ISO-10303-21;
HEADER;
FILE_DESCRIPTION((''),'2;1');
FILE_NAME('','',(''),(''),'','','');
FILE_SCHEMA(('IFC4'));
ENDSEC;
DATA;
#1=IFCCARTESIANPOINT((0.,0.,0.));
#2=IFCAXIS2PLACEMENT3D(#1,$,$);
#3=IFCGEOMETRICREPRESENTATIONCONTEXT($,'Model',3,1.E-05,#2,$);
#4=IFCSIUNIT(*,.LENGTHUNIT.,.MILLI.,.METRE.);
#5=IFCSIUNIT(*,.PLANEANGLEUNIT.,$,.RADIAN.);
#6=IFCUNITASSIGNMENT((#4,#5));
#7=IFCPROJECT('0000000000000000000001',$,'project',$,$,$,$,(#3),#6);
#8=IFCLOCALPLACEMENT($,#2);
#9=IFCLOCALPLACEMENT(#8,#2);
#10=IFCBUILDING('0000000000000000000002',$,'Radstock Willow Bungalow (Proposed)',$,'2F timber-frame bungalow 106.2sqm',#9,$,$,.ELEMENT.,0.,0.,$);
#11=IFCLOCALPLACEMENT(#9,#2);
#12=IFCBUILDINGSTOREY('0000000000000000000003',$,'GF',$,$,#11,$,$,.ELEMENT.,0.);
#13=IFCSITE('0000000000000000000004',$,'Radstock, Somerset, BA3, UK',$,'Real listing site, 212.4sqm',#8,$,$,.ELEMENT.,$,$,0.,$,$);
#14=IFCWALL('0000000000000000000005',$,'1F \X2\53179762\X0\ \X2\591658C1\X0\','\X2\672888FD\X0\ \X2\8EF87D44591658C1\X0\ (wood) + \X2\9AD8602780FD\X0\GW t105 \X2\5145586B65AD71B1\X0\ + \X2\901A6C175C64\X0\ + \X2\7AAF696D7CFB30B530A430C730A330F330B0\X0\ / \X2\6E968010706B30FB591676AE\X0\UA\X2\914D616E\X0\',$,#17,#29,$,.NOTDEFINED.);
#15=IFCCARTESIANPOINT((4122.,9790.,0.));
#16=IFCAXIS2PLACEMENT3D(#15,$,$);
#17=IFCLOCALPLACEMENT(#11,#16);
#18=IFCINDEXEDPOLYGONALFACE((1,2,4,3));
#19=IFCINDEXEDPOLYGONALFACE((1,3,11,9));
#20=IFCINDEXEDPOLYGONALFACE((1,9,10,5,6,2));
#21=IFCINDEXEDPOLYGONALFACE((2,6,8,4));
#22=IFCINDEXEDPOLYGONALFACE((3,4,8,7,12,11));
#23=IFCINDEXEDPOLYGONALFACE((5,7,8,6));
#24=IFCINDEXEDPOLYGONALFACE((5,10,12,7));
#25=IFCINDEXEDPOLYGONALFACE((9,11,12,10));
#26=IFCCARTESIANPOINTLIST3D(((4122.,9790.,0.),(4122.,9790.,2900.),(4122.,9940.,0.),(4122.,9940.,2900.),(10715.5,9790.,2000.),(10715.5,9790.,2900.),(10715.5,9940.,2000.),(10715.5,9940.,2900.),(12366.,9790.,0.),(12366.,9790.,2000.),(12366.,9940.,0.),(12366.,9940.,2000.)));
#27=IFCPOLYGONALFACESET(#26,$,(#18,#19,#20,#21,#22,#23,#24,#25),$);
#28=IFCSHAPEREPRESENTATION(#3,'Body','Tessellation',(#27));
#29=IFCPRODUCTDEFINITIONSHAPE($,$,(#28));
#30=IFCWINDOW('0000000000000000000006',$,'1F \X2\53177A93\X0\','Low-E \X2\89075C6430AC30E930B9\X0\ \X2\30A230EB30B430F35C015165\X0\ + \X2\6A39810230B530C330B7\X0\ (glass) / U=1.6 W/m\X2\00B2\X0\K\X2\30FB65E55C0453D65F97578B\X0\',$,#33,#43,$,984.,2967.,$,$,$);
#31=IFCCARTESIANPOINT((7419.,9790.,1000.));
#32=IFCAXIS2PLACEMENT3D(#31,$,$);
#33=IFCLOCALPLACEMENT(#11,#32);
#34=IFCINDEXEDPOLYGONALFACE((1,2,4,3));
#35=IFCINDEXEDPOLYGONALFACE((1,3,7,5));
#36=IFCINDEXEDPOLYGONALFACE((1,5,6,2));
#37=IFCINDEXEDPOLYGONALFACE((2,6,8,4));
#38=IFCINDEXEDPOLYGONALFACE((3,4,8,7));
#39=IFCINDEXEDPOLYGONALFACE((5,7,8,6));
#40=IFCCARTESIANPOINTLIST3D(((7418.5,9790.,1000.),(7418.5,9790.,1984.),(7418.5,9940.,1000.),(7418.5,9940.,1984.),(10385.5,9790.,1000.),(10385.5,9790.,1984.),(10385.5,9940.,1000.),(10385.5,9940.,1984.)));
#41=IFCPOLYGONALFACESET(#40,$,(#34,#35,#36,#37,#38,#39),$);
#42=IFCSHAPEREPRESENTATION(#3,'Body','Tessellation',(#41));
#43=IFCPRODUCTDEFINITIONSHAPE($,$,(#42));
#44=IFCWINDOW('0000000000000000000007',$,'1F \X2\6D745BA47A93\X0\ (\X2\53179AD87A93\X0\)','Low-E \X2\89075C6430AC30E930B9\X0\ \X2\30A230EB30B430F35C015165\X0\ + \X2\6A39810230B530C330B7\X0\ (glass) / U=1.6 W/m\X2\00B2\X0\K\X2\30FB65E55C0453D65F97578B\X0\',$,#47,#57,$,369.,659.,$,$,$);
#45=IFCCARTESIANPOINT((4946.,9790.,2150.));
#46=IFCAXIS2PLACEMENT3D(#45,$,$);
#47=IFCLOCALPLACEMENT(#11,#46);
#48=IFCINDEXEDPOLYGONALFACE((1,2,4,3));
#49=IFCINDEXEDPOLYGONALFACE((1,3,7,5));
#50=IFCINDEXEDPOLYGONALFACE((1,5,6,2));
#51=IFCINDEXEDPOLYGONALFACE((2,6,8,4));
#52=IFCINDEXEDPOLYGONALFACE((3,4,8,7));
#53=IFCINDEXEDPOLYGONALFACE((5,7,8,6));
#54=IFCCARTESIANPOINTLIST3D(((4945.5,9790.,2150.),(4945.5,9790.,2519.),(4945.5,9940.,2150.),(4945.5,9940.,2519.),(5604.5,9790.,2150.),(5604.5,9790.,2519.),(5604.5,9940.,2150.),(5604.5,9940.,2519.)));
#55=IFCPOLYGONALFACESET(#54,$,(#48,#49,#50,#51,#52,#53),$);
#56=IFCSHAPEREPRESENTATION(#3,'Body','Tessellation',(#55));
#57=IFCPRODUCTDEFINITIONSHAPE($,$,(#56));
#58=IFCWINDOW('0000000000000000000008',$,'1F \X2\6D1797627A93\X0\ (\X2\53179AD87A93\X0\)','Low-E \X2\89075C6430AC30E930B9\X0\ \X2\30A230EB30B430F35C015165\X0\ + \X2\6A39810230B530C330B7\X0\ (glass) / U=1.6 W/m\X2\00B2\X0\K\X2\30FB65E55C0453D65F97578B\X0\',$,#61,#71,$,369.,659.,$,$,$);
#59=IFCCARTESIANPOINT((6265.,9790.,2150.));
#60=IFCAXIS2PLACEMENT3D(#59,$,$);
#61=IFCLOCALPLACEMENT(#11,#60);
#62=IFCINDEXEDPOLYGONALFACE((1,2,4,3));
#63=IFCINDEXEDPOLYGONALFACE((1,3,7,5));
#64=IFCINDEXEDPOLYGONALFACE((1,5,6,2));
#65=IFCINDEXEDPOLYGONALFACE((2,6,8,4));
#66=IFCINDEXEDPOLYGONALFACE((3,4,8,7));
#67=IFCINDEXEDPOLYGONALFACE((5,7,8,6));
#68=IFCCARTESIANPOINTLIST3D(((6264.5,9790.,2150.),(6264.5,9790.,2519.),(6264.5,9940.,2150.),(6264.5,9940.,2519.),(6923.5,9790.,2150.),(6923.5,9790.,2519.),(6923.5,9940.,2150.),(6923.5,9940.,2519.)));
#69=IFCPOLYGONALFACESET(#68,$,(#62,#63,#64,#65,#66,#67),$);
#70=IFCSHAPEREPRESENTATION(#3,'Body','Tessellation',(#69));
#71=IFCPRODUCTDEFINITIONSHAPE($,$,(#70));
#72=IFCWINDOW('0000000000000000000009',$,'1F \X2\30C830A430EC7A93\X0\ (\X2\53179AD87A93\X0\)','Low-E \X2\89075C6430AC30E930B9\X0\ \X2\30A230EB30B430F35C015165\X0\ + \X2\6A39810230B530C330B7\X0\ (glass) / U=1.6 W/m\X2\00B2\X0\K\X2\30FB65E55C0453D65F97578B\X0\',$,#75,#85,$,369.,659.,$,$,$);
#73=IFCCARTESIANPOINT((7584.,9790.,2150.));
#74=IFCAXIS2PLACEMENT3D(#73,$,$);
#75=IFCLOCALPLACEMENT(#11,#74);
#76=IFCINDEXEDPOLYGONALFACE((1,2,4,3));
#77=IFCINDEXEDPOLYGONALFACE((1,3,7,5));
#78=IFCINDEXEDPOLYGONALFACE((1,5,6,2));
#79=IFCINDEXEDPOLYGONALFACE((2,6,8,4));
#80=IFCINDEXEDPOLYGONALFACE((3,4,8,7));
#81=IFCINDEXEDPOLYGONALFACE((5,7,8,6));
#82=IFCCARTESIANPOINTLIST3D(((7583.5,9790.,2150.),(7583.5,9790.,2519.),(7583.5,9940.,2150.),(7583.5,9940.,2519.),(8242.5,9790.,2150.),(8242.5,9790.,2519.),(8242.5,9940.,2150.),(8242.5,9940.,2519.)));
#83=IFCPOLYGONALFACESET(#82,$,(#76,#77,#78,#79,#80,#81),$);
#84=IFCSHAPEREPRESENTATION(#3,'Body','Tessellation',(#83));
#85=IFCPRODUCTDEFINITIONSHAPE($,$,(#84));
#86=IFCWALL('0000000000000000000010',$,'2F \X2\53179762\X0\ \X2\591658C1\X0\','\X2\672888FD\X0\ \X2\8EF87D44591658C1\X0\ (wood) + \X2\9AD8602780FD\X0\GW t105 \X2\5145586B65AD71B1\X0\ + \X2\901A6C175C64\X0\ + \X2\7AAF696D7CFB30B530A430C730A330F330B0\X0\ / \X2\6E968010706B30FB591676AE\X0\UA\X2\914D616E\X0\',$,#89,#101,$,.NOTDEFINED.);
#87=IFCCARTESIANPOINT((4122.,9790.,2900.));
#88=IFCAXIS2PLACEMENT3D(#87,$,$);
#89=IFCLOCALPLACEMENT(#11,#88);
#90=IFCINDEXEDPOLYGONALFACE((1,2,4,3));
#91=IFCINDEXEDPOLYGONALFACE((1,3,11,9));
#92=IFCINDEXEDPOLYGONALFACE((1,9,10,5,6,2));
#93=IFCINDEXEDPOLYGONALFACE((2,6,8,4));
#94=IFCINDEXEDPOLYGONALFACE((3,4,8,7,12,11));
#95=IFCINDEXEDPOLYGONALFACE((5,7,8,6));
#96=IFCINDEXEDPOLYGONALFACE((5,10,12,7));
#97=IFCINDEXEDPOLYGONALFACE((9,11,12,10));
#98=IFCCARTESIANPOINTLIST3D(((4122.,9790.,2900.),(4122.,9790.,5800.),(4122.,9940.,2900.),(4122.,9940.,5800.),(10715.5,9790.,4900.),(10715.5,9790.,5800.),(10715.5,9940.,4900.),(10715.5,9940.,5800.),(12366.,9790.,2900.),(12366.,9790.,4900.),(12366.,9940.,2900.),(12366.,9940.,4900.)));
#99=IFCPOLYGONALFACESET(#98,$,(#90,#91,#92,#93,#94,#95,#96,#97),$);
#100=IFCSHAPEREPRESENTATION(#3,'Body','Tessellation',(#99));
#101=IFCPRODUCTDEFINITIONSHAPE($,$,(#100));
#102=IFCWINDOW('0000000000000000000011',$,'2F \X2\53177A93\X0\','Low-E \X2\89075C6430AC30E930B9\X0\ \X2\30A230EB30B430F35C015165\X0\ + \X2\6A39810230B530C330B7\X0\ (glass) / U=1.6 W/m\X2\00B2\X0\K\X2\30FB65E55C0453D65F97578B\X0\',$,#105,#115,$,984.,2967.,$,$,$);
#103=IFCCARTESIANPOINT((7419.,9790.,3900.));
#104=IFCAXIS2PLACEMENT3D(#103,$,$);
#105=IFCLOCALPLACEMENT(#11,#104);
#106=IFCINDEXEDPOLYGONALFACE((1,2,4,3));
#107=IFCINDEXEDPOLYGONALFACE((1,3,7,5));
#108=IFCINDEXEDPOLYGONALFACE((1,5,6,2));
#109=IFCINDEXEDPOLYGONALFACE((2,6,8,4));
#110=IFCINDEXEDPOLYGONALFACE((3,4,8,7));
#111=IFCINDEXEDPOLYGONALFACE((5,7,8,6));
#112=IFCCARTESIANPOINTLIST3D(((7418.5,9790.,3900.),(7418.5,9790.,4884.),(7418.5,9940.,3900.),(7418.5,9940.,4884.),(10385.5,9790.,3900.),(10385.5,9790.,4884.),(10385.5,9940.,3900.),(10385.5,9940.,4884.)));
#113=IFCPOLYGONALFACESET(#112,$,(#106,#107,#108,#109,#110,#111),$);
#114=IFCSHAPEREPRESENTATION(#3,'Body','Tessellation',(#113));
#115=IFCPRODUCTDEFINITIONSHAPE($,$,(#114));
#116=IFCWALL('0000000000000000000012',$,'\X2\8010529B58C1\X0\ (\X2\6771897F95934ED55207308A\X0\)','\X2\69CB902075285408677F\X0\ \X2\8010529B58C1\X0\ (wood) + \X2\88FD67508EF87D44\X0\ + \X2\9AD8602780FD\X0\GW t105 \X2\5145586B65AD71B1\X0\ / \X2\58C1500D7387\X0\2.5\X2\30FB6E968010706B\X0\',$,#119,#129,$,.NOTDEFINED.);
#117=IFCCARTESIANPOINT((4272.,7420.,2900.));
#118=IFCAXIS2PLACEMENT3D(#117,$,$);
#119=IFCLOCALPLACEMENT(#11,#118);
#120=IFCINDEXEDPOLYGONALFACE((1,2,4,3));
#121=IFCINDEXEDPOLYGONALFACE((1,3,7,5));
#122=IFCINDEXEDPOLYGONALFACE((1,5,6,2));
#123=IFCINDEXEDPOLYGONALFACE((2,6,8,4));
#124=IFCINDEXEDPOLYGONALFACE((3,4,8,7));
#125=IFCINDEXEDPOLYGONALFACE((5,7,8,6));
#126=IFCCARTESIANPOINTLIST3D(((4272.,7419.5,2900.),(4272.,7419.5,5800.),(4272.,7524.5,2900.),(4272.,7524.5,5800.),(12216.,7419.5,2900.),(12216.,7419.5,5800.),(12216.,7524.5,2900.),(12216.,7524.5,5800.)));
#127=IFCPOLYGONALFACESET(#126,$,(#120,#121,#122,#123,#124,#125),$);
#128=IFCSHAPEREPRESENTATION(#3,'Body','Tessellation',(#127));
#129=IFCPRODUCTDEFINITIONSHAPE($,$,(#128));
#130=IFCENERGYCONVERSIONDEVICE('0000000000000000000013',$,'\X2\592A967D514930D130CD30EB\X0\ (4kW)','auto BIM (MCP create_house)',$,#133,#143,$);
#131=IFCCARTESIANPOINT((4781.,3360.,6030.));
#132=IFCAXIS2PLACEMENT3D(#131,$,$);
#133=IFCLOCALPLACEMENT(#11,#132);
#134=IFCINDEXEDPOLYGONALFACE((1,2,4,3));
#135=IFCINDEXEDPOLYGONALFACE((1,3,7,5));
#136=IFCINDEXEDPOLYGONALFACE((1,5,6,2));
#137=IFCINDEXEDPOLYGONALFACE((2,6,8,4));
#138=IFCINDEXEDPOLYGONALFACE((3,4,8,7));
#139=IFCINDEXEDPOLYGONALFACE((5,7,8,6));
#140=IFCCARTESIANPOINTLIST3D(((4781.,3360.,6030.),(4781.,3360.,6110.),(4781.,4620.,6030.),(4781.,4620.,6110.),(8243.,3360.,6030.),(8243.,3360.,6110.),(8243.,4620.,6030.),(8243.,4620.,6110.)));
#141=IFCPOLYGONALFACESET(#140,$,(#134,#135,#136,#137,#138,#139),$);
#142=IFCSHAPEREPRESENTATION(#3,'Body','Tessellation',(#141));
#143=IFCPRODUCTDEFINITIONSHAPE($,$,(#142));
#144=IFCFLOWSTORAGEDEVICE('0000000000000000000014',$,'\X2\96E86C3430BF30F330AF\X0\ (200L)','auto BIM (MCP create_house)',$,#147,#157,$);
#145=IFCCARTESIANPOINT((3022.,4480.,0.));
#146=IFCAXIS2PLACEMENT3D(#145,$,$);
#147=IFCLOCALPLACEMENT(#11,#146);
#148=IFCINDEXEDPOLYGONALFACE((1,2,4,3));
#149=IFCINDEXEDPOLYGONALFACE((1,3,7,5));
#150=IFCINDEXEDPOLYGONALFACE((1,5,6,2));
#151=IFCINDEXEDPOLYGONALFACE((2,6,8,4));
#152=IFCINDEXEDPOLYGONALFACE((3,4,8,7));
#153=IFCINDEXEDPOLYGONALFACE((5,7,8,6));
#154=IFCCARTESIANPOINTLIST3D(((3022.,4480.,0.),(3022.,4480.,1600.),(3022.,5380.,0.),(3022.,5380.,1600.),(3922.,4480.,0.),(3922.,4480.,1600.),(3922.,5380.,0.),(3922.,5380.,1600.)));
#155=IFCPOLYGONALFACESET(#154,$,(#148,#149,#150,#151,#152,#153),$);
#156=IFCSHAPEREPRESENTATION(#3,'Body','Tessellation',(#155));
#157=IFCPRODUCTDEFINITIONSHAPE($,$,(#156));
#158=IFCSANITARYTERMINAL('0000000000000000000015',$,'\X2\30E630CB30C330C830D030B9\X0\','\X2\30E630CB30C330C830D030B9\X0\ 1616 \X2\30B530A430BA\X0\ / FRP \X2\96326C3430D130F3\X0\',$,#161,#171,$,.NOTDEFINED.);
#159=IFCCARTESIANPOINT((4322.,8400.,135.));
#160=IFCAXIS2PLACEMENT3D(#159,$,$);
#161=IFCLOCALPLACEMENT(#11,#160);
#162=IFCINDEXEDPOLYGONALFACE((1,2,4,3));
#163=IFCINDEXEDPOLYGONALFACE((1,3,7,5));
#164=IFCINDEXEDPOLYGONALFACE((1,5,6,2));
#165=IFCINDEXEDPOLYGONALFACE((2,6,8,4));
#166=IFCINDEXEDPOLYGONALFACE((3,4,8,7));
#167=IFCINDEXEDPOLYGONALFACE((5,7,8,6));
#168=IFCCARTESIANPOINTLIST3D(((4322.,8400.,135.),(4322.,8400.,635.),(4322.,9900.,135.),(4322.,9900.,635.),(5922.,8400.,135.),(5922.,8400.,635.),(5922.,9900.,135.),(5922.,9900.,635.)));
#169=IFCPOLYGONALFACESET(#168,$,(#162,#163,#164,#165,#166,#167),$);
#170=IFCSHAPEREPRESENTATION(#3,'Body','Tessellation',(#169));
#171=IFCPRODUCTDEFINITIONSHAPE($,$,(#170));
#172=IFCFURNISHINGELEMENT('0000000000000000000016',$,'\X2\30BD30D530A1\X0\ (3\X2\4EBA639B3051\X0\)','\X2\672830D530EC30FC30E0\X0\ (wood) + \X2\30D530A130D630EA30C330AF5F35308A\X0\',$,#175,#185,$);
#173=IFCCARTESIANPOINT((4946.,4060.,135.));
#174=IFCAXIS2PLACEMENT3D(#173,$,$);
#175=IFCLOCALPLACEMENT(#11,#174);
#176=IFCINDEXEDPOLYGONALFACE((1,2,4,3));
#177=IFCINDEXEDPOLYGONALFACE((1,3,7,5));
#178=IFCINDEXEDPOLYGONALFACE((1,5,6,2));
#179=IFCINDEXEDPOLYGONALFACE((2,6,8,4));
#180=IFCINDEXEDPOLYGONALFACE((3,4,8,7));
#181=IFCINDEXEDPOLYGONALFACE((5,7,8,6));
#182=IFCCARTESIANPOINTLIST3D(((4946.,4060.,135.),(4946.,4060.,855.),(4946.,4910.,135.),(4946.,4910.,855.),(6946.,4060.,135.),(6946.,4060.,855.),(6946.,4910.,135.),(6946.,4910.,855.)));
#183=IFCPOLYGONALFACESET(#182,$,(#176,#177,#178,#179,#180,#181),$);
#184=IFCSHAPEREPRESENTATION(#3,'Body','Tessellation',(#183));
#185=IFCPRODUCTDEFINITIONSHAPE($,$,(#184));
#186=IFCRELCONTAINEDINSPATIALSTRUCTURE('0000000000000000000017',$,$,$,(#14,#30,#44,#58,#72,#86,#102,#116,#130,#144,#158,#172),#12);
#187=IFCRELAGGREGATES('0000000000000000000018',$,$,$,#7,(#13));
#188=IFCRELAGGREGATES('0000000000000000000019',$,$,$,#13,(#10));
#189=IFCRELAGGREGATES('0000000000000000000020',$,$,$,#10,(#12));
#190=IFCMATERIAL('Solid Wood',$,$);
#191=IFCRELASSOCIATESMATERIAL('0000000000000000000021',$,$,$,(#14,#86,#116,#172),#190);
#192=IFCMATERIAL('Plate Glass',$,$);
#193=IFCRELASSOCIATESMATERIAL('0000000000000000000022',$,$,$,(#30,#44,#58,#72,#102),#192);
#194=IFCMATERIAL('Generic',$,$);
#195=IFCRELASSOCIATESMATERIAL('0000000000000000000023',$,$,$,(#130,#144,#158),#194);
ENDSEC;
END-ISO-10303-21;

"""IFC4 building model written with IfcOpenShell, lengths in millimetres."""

from ifc_helpers import new_model, si_unit, frame, frame_2d, origin, place, context, project, spatial, rectangle, extrude, material, element, fill, save


model = new_model("IFC4")

# Units and contexts
model_context = context("Model", 3, precision=1e-05, world=origin())
ifc_project = project(units=[si_unit("LENGTHUNIT", "METRE", prefix="MILLI"), si_unit("PLANEANGLEUNIT", "RADIAN")], contexts=[model_context])

# Site, building, storey
site_placement = place(None, origin())
site = spatial("IfcSite", under=ifc_project, at=site_placement, Name="Radstock, Somerset, BA3, UK", ObjectType="Real listing site, 212.4sqm", CompositionType="ELEMENT", RefElevation=0.0)
building_placement = place(site_placement, origin())
building = spatial("IfcBuilding", under=site, at=building_placement, Name="Radstock Willow Bungalow (Proposed)", ObjectType="2F timber-frame bungalow 106.2sqm", CompositionType="ELEMENT", ElevationOfRefHeight=0.0, ElevationOfTerrain=0.0)
storey_placement = place(building_placement, origin())
storey = spatial("IfcBuildingStorey", under=building, at=storey_placement, Name="GF", CompositionType="ELEMENT", Elevation=0.0)

# Wall, openings, windows
ifc_material_1 = material(Name="Solid Wood")
wall_1_placement = place(storey_placement, frame((4122.0, 9790.0, 0.0)))
wall_1 = element("IfcWall", 1, at=wall_1_placement, inside=storey, material=ifc_material_1, Name="1F 北面 外壁", Description="木製 軸組外壁 (wood) + 高性能GW t105 充填断熱 + 通気層 + 窯業系サイディング / 準耐火・外皮UA配慮", PredefinedType="NOTDEFINED", context=model_context, shape_type="SweptSolid", body=[
    extrude(rectangle(XDim=8244.0, YDim=150.0, at=frame_2d((4122.0, 75.0))), frame((4122.0, 9790.0, 0.0)), (0.0, 0.0, 1.0), 2900.0),
])
opening_1_placement = place(storey_placement, frame((7419.0, 9790.0, 1000.0)))
opening_1 = element("IfcOpeningElement", 2, at=opening_1_placement, cuts=wall_1, PredefinedType="NOTDEFINED", context=model_context, shape_type="SweptSolid", body=[
    extrude(rectangle(XDim=2967.0, YDim=150.0, at=frame_2d((1483.0, 75.0))), frame((7419.0, 9790.0, 1000.0)), (0.0, 0.0, 1.0), 984.0),
])
opening_2_placement = place(storey_placement, frame((4946.0, 9790.0, 2150.0)))
opening_2 = element("IfcOpeningElement", 3, at=opening_2_placement, cuts=wall_1, PredefinedType="NOTDEFINED", context=model_context, shape_type="SweptSolid", body=[
    extrude(rectangle(XDim=659.0, YDim=150.0, at=frame_2d((329.0, 75.0))), frame((4946.0, 9790.0, 2150.0)), (0.0, 0.0, 1.0), 369.0),
])
opening_3_placement = place(storey_placement, frame((6265.0, 9790.0, 2150.0)))
opening_3 = element("IfcOpeningElement", 4, at=opening_3_placement, cuts=wall_1, PredefinedType="NOTDEFINED", context=model_context, shape_type="SweptSolid", body=[
    extrude(rectangle(XDim=659.0, YDim=150.0, at=frame_2d((329.0, 75.0))), frame((6265.0, 9790.0, 2150.0)), (0.0, 0.0, 1.0), 369.0),
])
opening_4_placement = place(storey_placement, frame((7584.0, 9790.0, 2150.0)))
opening_4 = element("IfcOpeningElement", 5, at=opening_4_placement, cuts=wall_1, PredefinedType="NOTDEFINED", context=model_context, shape_type="SweptSolid", body=[
    extrude(rectangle(XDim=659.0, YDim=150.0, at=frame_2d((329.0, 75.0))), frame((7584.0, 9790.0, 2150.0)), (0.0, 0.0, 1.0), 369.0),
])
ifc_material_2 = material(Name="Plate Glass")
window_1_placement = place(storey_placement, frame((7419.0, 9790.0, 1000.0)))
window_1 = element("IfcWindow", 6, at=window_1_placement, inside=storey, material=ifc_material_2, Name="1F 北窓", Description="Low-E 複層ガラス アルゴン封入 + 樹脂サッシ (glass) / U=1.6 W/m²K・日射取得型", OverallHeight=984.0, OverallWidth=2967.0, context=model_context, shape_type="SweptSolid", body=[
    extrude(rectangle(XDim=2967.0, YDim=150.0, at=frame_2d((1483.0, 75.0))), frame((7419.0, 9790.0, 1000.0)), (0.0, 0.0, 1.0), 984.0),
])
fill(opening_1, window_1)
window_2_placement = place(storey_placement, frame((4946.0, 9790.0, 2150.0)))
window_2 = element("IfcWindow", 7, at=window_2_placement, inside=storey, material=ifc_material_2, Name="1F 浴室窓 (北高窓)", Description="Low-E 複層ガラス アルゴン封入 + 樹脂サッシ (glass) / U=1.6 W/m²K・日射取得型", OverallHeight=369.0, OverallWidth=659.0, context=model_context, shape_type="SweptSolid", body=[
    extrude(rectangle(XDim=659.0, YDim=150.0, at=frame_2d((329.0, 75.0))), frame((4946.0, 9790.0, 2150.0)), (0.0, 0.0, 1.0), 369.0),
])
fill(opening_2, window_2)
window_3_placement = place(storey_placement, frame((6265.0, 9790.0, 2150.0)))
window_3 = element("IfcWindow", 8, at=window_3_placement, inside=storey, material=ifc_material_2, Name="1F 洗面窓 (北高窓)", Description="Low-E 複層ガラス アルゴン封入 + 樹脂サッシ (glass) / U=1.6 W/m²K・日射取得型", OverallHeight=369.0, OverallWidth=659.0, context=model_context, shape_type="SweptSolid", body=[
    extrude(rectangle(XDim=659.0, YDim=150.0, at=frame_2d((329.0, 75.0))), frame((6265.0, 9790.0, 2150.0)), (0.0, 0.0, 1.0), 369.0),
])
fill(opening_3, window_3)
window_4_placement = place(storey_placement, frame((7584.0, 9790.0, 2150.0)))
window_4 = element("IfcWindow", 9, at=window_4_placement, inside=storey, material=ifc_material_2, Name="1F トイレ窓 (北高窓)", Description="Low-E 複層ガラス アルゴン封入 + 樹脂サッシ (glass) / U=1.6 W/m²K・日射取得型", OverallHeight=369.0, OverallWidth=659.0, context=model_context, shape_type="SweptSolid", body=[
    extrude(rectangle(XDim=659.0, YDim=150.0, at=frame_2d((329.0, 75.0))), frame((7584.0, 9790.0, 2150.0)), (0.0, 0.0, 1.0), 369.0),
])
fill(opening_4, window_4)

# Wall, opening, window
wall_2_placement = place(storey_placement, frame((4122.0, 9790.0, 2900.0)))
wall_2 = element("IfcWall", 10, at=wall_2_placement, inside=storey, material=ifc_material_1, Name="2F 北面 外壁", Description="木製 軸組外壁 (wood) + 高性能GW t105 充填断熱 + 通気層 + 窯業系サイディング / 準耐火・外皮UA配慮", PredefinedType="NOTDEFINED", context=model_context, shape_type="SweptSolid", body=[
    extrude(rectangle(XDim=8244.0, YDim=150.0, at=frame_2d((4122.0, 75.0))), frame((4122.0, 9790.0, 2900.0)), (0.0, 0.0, 1.0), 2900.0),
])
opening_5_placement = place(storey_placement, frame((7419.0, 9790.0, 3900.0)))
opening_5 = element("IfcOpeningElement", 11, at=opening_5_placement, cuts=wall_2, PredefinedType="NOTDEFINED", context=model_context, shape_type="SweptSolid", body=[
    extrude(rectangle(XDim=2967.0, YDim=150.0, at=frame_2d((1483.0, 75.0))), frame((7419.0, 9790.0, 3900.0)), (0.0, 0.0, 1.0), 984.0),
])
window_5_placement = place(storey_placement, frame((7419.0, 9790.0, 3900.0)))
window_5 = element("IfcWindow", 12, at=window_5_placement, inside=storey, material=ifc_material_2, Name="2F 北窓", Description="Low-E 複層ガラス アルゴン封入 + 樹脂サッシ (glass) / U=1.6 W/m²K・日射取得型", OverallHeight=984.0, OverallWidth=2967.0, context=model_context, shape_type="SweptSolid", body=[
    extrude(rectangle(XDim=2967.0, YDim=150.0, at=frame_2d((1483.0, 75.0))), frame((7419.0, 9790.0, 3900.0)), (0.0, 0.0, 1.0), 984.0),
])
fill(opening_5, window_5)

# Wall
wall_3_placement = place(storey_placement, frame((4272.0, 7420.0, 2900.0)))
element("IfcWall", 13, at=wall_3_placement, inside=storey, material=ifc_material_1, Name="耐力壁 (東西間仕切り)", Description="構造用合板 耐力壁 (wood) + 製材軸組 + 高性能GW t105 充填断熱 / 壁倍率2.5・準耐火", PredefinedType="NOTDEFINED", context=model_context, shape_type="SweptSolid", body=[
    extrude(rectangle(XDim=7944.0, YDim=105.0, at=frame_2d((3972.0, 52.0))), frame((4272.0, 7420.0, 2900.0)), (0.0, 0.0, 1.0), 2900.0),
])

# Energy conversion device
ifc_material_3 = material(Name="Generic")
energy_conversion_device_placement = place(storey_placement, frame((4781.0, 3360.0, 6030.0)))
element("IfcEnergyConversionDevice", 14, at=energy_conversion_device_placement, inside=storey, material=ifc_material_3, Name="太陽光パネル (4kW)", Description="auto BIM (MCP create_house)", context=model_context, shape_type="SweptSolid", body=[
    extrude(rectangle(XDim=3462.0, YDim=1260.0, at=frame_2d((1731.0, 630.0))), frame((4781.0, 3360.0, 6030.0)), (0.0, 0.0, 1.0), 80.0),
])

# Flow storage device
flow_storage_device_placement = place(storey_placement, frame((3022.0, 4480.0, 0.0)))
element("IfcFlowStorageDevice", 15, at=flow_storage_device_placement, inside=storey, material=ifc_material_3, Name="雨水タンク (200L)", Description="auto BIM (MCP create_house)", context=model_context, shape_type="SweptSolid", body=[
    extrude(rectangle(XDim=900.0, YDim=900.0, at=frame_2d((450.0, 450.0))), frame((3022.0, 4480.0, 0.0)), (0.0, 0.0, 1.0), 1600.0),
])

# Sanitary terminal
sanitary_terminal_placement = place(storey_placement, frame((4322.0, 8400.0, 135.0)))
element("IfcSanitaryTerminal", 16, at=sanitary_terminal_placement, inside=storey, material=ifc_material_3, Name="ユニットバス", Description="ユニットバス 1616 サイズ / FRP 防水パン", PredefinedType="NOTDEFINED", context=model_context, shape_type="SweptSolid", body=[
    extrude(rectangle(XDim=1600.0, YDim=1500.0, at=frame_2d((800.0, 750.0))), frame((4322.0, 8400.0, 135.0)), (0.0, 0.0, 1.0), 500.0),
])

# Furnishing element
furnishing_1_placement = place(storey_placement, frame((4946.0, 4060.0, 135.0)))
element("IfcFurnishingElement", 17, at=furnishing_1_placement, inside=storey, material=ifc_material_1, Name="ソファ (3人掛け)", Description="木フレーム (wood) + ファブリック張り", context=model_context, shape_type="SweptSolid", body=[
    extrude(rectangle(XDim=2000.0, YDim=850.0, at=frame_2d((1000.0, 425.0))), frame((4946.0, 4060.0, 135.0)), (0.0, 0.0, 1.0), 720.0),
])

save(model, "model.ifc")
